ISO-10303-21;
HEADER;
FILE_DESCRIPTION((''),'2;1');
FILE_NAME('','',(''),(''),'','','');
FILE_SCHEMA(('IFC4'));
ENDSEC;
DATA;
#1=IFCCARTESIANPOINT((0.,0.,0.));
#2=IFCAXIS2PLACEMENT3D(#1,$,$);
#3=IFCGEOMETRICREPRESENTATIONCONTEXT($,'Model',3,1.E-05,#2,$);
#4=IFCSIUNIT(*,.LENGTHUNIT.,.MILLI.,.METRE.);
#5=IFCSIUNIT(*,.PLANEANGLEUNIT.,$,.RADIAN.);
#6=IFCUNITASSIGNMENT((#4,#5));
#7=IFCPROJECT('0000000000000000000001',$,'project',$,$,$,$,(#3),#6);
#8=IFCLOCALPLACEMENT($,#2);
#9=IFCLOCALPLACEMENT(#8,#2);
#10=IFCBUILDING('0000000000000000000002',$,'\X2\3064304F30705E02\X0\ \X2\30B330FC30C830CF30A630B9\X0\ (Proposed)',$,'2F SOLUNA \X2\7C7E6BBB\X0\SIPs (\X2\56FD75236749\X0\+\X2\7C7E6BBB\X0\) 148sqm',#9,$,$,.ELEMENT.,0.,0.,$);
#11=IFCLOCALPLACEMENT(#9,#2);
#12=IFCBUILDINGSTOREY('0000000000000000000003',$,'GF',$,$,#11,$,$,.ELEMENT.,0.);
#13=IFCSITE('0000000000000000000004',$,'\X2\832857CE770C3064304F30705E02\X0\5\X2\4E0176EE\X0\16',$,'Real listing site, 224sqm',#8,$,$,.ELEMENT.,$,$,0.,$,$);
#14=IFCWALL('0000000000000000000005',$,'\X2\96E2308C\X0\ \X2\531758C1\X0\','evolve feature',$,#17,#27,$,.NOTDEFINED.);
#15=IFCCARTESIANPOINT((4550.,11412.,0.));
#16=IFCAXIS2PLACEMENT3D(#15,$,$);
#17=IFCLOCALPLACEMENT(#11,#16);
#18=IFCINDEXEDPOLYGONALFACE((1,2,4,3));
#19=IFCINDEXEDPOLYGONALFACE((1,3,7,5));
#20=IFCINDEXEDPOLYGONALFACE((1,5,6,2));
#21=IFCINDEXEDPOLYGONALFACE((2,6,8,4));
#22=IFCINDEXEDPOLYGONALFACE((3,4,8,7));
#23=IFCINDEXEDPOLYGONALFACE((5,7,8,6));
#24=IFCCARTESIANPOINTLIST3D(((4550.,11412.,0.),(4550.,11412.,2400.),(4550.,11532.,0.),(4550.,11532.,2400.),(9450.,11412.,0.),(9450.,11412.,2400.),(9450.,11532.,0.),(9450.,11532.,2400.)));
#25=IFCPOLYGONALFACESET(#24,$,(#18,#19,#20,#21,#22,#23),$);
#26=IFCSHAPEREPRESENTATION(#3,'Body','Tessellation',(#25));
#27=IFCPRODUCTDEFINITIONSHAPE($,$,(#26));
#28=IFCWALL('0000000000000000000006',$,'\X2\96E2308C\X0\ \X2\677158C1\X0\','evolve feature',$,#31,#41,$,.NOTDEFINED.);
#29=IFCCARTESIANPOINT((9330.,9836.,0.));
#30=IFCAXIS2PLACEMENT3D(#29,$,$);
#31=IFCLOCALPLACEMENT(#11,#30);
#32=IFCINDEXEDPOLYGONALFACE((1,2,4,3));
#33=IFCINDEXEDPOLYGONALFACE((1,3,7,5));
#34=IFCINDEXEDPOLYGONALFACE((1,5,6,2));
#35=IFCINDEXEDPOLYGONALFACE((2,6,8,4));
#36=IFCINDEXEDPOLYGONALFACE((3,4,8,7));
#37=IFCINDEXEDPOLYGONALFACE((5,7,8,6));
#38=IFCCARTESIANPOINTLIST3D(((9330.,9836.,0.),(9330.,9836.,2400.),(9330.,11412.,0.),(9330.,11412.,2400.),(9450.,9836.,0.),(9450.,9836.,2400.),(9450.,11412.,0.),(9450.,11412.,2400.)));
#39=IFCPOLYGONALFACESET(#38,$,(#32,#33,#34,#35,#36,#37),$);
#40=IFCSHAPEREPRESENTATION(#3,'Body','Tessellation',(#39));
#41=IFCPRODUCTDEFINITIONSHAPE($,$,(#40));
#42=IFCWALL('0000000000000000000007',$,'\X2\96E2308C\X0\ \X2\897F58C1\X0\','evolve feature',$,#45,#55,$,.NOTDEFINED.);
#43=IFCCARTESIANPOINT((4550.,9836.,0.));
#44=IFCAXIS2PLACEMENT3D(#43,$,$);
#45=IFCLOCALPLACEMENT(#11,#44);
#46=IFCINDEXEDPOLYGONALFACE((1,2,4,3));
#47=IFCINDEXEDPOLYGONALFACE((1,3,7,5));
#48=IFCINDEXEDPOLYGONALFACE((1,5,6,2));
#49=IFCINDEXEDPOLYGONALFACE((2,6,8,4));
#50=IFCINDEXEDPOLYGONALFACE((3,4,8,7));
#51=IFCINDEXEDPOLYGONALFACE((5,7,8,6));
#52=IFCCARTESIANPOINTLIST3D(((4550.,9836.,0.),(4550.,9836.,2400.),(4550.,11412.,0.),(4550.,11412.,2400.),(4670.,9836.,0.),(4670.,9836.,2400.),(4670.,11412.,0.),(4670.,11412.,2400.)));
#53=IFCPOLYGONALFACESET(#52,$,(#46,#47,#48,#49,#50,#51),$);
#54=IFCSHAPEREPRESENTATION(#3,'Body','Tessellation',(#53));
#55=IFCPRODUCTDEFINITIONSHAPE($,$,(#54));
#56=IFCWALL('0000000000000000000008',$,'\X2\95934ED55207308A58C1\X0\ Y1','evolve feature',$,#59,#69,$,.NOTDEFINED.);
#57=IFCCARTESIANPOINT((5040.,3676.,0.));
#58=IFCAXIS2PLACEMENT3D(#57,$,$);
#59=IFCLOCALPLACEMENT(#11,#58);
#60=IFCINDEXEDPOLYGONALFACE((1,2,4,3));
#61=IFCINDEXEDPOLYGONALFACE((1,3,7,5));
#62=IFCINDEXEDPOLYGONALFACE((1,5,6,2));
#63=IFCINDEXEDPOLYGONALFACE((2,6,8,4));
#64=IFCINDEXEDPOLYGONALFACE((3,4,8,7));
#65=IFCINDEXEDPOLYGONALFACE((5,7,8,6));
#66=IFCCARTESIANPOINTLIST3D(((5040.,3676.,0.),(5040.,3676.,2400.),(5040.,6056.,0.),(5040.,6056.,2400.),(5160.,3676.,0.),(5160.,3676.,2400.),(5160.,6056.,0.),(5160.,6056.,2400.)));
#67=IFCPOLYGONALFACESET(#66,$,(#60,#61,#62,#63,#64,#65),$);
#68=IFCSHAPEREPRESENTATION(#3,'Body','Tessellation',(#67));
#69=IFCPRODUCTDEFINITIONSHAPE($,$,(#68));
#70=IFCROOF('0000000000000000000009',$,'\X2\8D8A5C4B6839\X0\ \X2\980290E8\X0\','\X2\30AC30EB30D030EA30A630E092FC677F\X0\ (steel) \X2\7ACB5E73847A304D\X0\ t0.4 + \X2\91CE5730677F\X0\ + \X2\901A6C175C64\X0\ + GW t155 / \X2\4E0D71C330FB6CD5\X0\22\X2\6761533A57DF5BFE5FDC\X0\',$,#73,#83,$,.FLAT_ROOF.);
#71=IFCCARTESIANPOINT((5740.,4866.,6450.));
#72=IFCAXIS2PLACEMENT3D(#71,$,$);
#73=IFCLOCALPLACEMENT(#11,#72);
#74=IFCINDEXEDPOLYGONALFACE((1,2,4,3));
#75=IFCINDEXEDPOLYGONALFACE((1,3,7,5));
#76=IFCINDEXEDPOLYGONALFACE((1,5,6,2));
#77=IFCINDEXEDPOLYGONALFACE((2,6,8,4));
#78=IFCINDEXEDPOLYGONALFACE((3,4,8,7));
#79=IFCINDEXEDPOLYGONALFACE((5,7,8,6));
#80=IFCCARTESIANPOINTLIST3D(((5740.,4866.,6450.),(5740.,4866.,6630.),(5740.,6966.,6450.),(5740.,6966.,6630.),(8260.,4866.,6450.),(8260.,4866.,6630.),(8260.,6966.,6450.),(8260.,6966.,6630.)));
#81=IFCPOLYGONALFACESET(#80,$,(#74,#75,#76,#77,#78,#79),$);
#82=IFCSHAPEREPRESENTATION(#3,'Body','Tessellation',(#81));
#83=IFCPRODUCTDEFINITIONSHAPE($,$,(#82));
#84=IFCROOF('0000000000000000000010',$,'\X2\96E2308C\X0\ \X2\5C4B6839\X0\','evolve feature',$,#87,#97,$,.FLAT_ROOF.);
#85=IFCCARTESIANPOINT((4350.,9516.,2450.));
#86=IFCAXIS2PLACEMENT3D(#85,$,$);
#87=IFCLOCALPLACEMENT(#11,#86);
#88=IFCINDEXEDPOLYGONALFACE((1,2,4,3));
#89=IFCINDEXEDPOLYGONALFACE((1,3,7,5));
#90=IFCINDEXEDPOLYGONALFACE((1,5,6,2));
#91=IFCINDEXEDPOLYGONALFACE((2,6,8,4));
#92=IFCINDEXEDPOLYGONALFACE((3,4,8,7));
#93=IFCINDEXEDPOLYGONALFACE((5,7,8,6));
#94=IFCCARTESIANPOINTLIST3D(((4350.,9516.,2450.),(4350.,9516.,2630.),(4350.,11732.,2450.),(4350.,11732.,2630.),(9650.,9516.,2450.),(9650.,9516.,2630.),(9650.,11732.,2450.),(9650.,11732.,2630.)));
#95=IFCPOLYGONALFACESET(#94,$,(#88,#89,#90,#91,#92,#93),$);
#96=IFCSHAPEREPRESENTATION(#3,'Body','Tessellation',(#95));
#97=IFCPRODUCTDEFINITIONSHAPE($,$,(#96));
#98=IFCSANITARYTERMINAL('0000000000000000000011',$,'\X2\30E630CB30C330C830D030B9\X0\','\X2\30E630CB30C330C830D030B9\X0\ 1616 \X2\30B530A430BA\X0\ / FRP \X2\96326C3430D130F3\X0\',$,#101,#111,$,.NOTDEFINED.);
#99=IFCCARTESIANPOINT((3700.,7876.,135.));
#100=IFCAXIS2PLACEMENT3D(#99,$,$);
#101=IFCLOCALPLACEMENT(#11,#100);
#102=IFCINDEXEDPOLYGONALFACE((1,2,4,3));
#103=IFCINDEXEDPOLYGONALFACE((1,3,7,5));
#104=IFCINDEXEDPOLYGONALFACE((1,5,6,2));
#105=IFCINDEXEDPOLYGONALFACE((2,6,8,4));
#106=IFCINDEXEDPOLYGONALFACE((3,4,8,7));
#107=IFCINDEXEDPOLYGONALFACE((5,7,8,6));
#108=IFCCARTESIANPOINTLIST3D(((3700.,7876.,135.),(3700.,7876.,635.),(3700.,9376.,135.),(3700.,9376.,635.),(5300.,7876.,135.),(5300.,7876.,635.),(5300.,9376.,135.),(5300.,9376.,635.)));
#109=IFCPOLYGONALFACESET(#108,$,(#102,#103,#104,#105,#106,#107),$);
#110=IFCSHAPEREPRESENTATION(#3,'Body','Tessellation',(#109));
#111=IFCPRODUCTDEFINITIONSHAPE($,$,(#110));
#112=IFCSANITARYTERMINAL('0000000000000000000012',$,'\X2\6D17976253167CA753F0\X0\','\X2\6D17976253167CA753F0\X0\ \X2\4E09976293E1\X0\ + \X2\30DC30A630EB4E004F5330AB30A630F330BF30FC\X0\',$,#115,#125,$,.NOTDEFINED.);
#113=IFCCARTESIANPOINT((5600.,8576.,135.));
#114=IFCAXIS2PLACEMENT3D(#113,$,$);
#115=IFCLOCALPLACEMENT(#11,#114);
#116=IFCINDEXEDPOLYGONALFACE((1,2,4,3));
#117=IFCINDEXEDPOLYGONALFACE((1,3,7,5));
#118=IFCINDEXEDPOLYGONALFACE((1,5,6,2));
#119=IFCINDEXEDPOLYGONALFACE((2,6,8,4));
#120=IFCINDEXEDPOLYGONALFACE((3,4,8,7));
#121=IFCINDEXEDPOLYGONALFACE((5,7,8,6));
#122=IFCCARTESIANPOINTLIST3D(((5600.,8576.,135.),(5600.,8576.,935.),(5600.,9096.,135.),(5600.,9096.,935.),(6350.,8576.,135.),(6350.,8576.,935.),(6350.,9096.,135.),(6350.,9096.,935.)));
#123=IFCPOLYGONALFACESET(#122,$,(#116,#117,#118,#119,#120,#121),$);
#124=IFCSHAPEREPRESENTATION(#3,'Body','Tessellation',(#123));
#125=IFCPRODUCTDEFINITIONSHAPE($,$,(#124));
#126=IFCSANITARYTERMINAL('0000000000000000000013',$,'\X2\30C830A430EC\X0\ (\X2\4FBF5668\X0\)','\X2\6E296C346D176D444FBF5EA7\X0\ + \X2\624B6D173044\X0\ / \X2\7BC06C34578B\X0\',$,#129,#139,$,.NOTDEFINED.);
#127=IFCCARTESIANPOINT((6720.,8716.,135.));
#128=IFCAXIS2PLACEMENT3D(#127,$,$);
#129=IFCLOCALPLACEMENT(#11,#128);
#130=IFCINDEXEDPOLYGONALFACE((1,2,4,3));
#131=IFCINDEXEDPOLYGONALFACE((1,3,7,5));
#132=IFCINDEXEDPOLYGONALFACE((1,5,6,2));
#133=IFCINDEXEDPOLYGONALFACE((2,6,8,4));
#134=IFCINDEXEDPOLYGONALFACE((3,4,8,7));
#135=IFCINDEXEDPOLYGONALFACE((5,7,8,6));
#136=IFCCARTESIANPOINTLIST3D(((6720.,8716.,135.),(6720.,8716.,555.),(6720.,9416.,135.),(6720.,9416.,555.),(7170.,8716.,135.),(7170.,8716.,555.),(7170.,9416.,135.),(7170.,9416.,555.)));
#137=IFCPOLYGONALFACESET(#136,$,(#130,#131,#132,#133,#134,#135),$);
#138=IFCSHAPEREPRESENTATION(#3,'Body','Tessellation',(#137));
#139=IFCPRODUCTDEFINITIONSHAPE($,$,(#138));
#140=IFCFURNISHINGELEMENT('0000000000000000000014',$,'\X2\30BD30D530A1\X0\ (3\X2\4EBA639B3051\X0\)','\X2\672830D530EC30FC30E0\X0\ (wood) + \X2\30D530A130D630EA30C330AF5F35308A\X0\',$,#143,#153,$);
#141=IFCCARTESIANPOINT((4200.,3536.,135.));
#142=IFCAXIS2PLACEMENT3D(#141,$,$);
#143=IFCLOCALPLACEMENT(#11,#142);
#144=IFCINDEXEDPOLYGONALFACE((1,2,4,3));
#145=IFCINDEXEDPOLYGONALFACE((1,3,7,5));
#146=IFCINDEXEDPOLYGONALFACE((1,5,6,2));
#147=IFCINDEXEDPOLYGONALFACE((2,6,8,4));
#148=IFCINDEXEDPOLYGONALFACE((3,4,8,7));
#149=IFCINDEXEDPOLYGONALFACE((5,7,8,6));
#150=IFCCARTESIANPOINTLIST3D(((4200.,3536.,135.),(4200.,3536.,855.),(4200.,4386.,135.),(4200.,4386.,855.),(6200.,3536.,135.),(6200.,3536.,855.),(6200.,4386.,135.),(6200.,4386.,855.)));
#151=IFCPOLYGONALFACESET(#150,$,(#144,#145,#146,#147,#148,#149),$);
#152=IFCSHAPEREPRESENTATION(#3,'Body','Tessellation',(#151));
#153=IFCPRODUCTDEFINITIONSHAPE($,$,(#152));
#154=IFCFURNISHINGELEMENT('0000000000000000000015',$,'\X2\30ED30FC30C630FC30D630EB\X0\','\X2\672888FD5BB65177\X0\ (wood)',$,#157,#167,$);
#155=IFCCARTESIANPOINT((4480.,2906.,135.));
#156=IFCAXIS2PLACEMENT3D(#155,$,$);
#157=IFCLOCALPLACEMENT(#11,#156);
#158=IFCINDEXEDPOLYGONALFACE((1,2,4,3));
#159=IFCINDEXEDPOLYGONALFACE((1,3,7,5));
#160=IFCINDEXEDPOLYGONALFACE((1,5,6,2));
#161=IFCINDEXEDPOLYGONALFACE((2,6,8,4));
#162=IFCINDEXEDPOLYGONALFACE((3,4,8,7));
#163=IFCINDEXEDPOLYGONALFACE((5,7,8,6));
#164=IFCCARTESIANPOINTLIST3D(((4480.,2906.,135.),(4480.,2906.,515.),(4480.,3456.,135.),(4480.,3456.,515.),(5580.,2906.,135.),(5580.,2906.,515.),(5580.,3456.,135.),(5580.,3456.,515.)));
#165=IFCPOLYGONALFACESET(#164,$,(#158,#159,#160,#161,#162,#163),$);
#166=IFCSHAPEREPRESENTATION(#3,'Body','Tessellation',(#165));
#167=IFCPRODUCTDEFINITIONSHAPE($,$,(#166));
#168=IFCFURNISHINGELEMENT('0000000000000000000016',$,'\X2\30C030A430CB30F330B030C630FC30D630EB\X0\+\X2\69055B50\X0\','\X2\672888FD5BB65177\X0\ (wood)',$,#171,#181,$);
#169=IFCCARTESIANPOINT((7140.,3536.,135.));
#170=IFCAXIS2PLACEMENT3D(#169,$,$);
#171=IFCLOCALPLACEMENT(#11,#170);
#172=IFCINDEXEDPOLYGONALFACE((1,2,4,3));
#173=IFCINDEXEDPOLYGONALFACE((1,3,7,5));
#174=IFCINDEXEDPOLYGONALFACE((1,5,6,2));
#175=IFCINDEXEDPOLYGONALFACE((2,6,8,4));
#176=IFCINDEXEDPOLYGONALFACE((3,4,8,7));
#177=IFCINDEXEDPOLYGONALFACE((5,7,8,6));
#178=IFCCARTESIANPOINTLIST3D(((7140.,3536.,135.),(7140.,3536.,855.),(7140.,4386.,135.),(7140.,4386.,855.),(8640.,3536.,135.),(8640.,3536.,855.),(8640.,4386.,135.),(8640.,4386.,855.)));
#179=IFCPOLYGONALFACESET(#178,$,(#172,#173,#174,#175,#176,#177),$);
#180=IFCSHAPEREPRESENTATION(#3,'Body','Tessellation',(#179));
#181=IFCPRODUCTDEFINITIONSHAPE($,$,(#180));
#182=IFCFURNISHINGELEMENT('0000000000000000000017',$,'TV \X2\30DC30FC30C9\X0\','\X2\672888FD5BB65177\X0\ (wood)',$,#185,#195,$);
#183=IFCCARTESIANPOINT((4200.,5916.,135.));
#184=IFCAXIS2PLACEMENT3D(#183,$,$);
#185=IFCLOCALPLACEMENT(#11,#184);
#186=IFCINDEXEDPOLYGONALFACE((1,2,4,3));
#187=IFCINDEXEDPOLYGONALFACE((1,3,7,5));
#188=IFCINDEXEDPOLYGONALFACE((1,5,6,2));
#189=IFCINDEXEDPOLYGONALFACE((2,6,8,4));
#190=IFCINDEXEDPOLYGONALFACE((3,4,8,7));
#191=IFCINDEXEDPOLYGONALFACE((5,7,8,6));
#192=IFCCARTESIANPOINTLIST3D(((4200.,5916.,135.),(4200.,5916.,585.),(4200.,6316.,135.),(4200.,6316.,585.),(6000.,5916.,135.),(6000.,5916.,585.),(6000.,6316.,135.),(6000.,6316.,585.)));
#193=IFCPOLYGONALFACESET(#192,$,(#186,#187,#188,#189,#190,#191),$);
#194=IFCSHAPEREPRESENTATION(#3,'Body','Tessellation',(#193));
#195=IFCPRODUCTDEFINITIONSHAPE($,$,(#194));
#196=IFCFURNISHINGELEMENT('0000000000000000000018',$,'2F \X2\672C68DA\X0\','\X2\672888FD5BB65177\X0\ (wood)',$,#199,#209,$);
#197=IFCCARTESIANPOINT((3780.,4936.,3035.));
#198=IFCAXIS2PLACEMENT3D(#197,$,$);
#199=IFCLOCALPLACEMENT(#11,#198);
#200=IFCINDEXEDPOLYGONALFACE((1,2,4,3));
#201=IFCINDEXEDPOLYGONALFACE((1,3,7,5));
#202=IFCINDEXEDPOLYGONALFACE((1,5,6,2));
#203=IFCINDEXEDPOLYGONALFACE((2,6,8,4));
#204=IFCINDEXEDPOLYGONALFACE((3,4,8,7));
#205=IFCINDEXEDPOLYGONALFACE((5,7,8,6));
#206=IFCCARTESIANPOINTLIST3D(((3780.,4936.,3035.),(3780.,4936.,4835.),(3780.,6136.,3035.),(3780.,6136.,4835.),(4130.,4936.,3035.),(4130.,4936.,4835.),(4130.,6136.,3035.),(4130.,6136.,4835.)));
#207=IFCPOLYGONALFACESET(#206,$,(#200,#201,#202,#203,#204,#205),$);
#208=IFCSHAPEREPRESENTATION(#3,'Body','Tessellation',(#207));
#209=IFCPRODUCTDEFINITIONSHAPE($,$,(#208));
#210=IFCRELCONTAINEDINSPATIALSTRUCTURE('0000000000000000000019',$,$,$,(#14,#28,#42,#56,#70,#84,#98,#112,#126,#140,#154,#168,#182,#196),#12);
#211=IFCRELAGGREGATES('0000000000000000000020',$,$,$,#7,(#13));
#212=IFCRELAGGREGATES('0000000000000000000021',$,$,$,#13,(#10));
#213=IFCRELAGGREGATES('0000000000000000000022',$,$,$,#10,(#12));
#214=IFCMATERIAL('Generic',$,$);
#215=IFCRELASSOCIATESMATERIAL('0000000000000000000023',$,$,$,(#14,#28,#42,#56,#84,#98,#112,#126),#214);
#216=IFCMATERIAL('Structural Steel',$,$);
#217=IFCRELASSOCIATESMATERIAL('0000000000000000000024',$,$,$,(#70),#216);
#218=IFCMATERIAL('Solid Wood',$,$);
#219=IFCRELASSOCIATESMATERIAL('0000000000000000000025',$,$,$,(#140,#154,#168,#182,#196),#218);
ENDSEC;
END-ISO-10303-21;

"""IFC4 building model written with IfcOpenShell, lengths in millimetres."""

from ifc_helpers import new_model, si_unit, frame, frame_2d, origin, place, context, project, spatial, rectangle, extrude, material, element, save


model = new_model("IFC4")

# Units and contexts
model_context = context("Model", 3, precision=1e-05, world=origin())
ifc_project = project(units=[si_unit("LENGTHUNIT", "METRE", prefix="MILLI"), si_unit("PLANEANGLEUNIT", "RADIAN")], contexts=[model_context])

# Site, building, storey
site_placement = place(None, origin())
site = spatial("IfcSite", under=ifc_project, at=site_placement, Name="茨城県つくば市5丁目16", ObjectType="Real listing site, 224sqm", CompositionType="ELEMENT", RefElevation=0.0)
building_placement = place(site_placement, origin())
building = spatial("IfcBuilding", under=site, at=building_placement, Name="つくば市 コートハウス (Proposed)", ObjectType="2F SOLUNA 籾殻SIPs (国産杉+籾殻) 148sqm", CompositionType="ELEMENT", ElevationOfRefHeight=0.0, ElevationOfTerrain=0.0)
storey_placement = place(building_placement, origin())
storey = spatial("IfcBuildingStorey", under=building, at=storey_placement, Name="GF", CompositionType="ELEMENT", Elevation=0.0)

# Shared definitions
ifc_material_1 = material(Name="Generic")

# Shared definitions
ifc_material_2 = material(Name="Solid Wood")

# Walls
wall_1_placement = place(storey_placement, frame((4550.0, 11412.0, 0.0)))
element("IfcWall", 1, at=wall_1_placement, inside=storey, material=ifc_material_1, Name="離れ 北壁", Description="evolve feature", PredefinedType="NOTDEFINED", context=model_context, shape_type="SweptSolid", body=[
    extrude(rectangle(XDim=4900.0, YDim=120.0, at=frame_2d((2450.0, 60.0))), frame((4550.0, 11412.0, 0.0)), (0.0, 0.0, 1.0), 2400.0),
])
wall_2_placement = place(storey_placement, frame((9330.0, 9836.0, 0.0)))
element("IfcWall", 2, at=wall_2_placement, inside=storey, material=ifc_material_1, Name="離れ 東壁", Description="evolve feature", PredefinedType="NOTDEFINED", context=model_context, shape_type="SweptSolid", body=[
    extrude(rectangle(XDim=120.0, YDim=1576.0, at=frame_2d((60.0, 788.0))), frame((9330.0, 9836.0, 0.0)), (0.0, 0.0, 1.0), 2400.0),
])
wall_3_placement = place(storey_placement, frame((4550.0, 9836.0, 0.0)))
element("IfcWall", 3, at=wall_3_placement, inside=storey, material=ifc_material_1, Name="離れ 西壁", Description="evolve feature", PredefinedType="NOTDEFINED", context=model_context, shape_type="SweptSolid", body=[
    extrude(rectangle(XDim=120.0, YDim=1576.0, at=frame_2d((60.0, 788.0))), frame((4550.0, 9836.0, 0.0)), (0.0, 0.0, 1.0), 2400.0),
])
wall_4_placement = place(storey_placement, frame((5040.0, 3676.0, 0.0)))
element("IfcWall", 4, at=wall_4_placement, inside=storey, material=ifc_material_1, Name="間仕切り壁 Y1", Description="evolve feature", PredefinedType="NOTDEFINED", context=model_context, shape_type="SweptSolid", body=[
    extrude(rectangle(XDim=120.0, YDim=2380.0, at=frame_2d((60.0, 1190.0))), frame((5040.0, 3676.0, 0.0)), (0.0, 0.0, 1.0), 2400.0),
])

# Roofs
ifc_material_3 = material(Name="Structural Steel")
roof_1_placement = place(storey_placement, frame((5740.0, 4866.0, 6450.0)))
element("IfcRoof", 5, at=roof_1_placement, inside=storey, material=ifc_material_3, Name="越屋根 頂部", Description="ガルバリウム鋼板 (steel) 立平葺き t0.4 + 野地板 + 通気層 + GW t155 / 不燃・法22条区域対応", PredefinedType="FLAT_ROOF", context=model_context, shape_type="SweptSolid", body=[
    extrude(rectangle(XDim=2520.0, YDim=2100.0, at=frame_2d((1260.0, 1050.0))), frame((5740.0, 4866.0, 6450.0)), (0.0, 0.0, 1.0), 180.0),
])
roof_2_placement = place(storey_placement, frame((4350.0, 9516.0, 2450.0)))
element("IfcRoof", 6, at=roof_2_placement, inside=storey, material=ifc_material_1, Name="離れ 屋根", Description="evolve feature", PredefinedType="FLAT_ROOF", context=model_context, shape_type="SweptSolid", body=[
    extrude(rectangle(XDim=5300.0, YDim=2216.0, at=frame_2d((2650.0, 1108.0))), frame((4350.0, 9516.0, 2450.0)), (0.0, 0.0, 1.0), 180.0),
])

# Sanitary terminals
sanitary_terminal_1_placement = place(storey_placement, frame((3700.0, 7876.0, 135.0)))
element("IfcSanitaryTerminal", 7, at=sanitary_terminal_1_placement, inside=storey, material=ifc_material_1, Name="ユニットバス", Description="ユニットバス 1616 サイズ / FRP 防水パン", PredefinedType="NOTDEFINED", context=model_context, shape_type="SweptSolid", body=[
    extrude(rectangle(XDim=1600.0, YDim=1500.0, at=frame_2d((800.0, 750.0))), frame((3700.0, 7876.0, 135.0)), (0.0, 0.0, 1.0), 500.0),
])
sanitary_terminal_2_placement = place(storey_placement, frame((5600.0, 8576.0, 135.0)))
element("IfcSanitaryTerminal", 8, at=sanitary_terminal_2_placement, inside=storey, material=ifc_material_1, Name="洗面化粧台", Description="洗面化粧台 三面鏡 + ボウル一体カウンター", PredefinedType="NOTDEFINED", context=model_context, shape_type="SweptSolid", body=[
    extrude(rectangle(XDim=750.0, YDim=520.0, at=frame_2d((375.0, 260.0))), frame((5600.0, 8576.0, 135.0)), (0.0, 0.0, 1.0), 800.0),
])
sanitary_terminal_3_placement = place(storey_placement, frame((6720.0, 8716.0, 135.0)))
element("IfcSanitaryTerminal", 9, at=sanitary_terminal_3_placement, inside=storey, material=ifc_material_1, Name="トイレ (便器)", Description="温水洗浄便座 + 手洗い / 節水型", PredefinedType="NOTDEFINED", context=model_context, shape_type="SweptSolid", body=[
    extrude(rectangle(XDim=450.0, YDim=700.0, at=frame_2d((225.0, 350.0))), frame((6720.0, 8716.0, 135.0)), (0.0, 0.0, 1.0), 420.0),
])

# Furnishing elements
furnishing_1_placement = place(storey_placement, frame((4200.0, 3536.0, 135.0)))
element("IfcFurnishingElement", 10, at=furnishing_1_placement, inside=storey, material=ifc_material_2, Name="ソファ (3人掛け)", Description="木フレーム (wood) + ファブリック張り", context=model_context, shape_type="SweptSolid", body=[
    extrude(rectangle(XDim=2000.0, YDim=850.0, at=frame_2d((1000.0, 425.0))), frame((4200.0, 3536.0, 135.0)), (0.0, 0.0, 1.0), 720.0),
])
furnishing_2_placement = place(storey_placement, frame((4480.0, 2906.0, 135.0)))
element("IfcFurnishingElement", 11, at=furnishing_2_placement, inside=storey, material=ifc_material_2, Name="ローテーブル", Description="木製家具 (wood)", context=model_context, shape_type="SweptSolid", body=[
    extrude(rectangle(XDim=1100.0, YDim=550.0, at=frame_2d((550.0, 275.0))), frame((4480.0, 2906.0, 135.0)), (0.0, 0.0, 1.0), 380.0),
])
furnishing_3_placement = place(storey_placement, frame((7140.0, 3536.0, 135.0)))
element("IfcFurnishingElement", 12, at=furnishing_3_placement, inside=storey, material=ifc_material_2, Name="ダイニングテーブル+椅子", Description="木製家具 (wood)", context=model_context, shape_type="SweptSolid", body=[
    extrude(rectangle(XDim=1500.0, YDim=850.0, at=frame_2d((750.0, 425.0))), frame((7140.0, 3536.0, 135.0)), (0.0, 0.0, 1.0), 720.0),
])
furnishing_4_placement = place(storey_placement, frame((4200.0, 5916.0, 135.0)))
element("IfcFurnishingElement", 13, at=furnishing_4_placement, inside=storey, material=ifc_material_2, Name="TV ボード", Description="木製家具 (wood)", context=model_context, shape_type="SweptSolid", body=[
    extrude(rectangle(XDim=1800.0, YDim=400.0, at=frame_2d((900.0, 200.0))), frame((4200.0, 5916.0, 135.0)), (0.0, 0.0, 1.0), 450.0),
])
furnishing_5_placement = place(storey_placement, frame((3780.0, 4936.0, 3035.0)))
element("IfcFurnishingElement", 14, at=furnishing_5_placement, inside=storey, material=ifc_material_2, Name="2F 本棚", Description="木製家具 (wood)", context=model_context, shape_type="SweptSolid", body=[
    extrude(rectangle(XDim=350.0, YDim=1200.0, at=frame_2d((175.0, 600.0))), frame((3780.0, 4936.0, 3035.0)), (0.0, 0.0, 1.0), 1800.0),
])

save(model, "model.ifc")
